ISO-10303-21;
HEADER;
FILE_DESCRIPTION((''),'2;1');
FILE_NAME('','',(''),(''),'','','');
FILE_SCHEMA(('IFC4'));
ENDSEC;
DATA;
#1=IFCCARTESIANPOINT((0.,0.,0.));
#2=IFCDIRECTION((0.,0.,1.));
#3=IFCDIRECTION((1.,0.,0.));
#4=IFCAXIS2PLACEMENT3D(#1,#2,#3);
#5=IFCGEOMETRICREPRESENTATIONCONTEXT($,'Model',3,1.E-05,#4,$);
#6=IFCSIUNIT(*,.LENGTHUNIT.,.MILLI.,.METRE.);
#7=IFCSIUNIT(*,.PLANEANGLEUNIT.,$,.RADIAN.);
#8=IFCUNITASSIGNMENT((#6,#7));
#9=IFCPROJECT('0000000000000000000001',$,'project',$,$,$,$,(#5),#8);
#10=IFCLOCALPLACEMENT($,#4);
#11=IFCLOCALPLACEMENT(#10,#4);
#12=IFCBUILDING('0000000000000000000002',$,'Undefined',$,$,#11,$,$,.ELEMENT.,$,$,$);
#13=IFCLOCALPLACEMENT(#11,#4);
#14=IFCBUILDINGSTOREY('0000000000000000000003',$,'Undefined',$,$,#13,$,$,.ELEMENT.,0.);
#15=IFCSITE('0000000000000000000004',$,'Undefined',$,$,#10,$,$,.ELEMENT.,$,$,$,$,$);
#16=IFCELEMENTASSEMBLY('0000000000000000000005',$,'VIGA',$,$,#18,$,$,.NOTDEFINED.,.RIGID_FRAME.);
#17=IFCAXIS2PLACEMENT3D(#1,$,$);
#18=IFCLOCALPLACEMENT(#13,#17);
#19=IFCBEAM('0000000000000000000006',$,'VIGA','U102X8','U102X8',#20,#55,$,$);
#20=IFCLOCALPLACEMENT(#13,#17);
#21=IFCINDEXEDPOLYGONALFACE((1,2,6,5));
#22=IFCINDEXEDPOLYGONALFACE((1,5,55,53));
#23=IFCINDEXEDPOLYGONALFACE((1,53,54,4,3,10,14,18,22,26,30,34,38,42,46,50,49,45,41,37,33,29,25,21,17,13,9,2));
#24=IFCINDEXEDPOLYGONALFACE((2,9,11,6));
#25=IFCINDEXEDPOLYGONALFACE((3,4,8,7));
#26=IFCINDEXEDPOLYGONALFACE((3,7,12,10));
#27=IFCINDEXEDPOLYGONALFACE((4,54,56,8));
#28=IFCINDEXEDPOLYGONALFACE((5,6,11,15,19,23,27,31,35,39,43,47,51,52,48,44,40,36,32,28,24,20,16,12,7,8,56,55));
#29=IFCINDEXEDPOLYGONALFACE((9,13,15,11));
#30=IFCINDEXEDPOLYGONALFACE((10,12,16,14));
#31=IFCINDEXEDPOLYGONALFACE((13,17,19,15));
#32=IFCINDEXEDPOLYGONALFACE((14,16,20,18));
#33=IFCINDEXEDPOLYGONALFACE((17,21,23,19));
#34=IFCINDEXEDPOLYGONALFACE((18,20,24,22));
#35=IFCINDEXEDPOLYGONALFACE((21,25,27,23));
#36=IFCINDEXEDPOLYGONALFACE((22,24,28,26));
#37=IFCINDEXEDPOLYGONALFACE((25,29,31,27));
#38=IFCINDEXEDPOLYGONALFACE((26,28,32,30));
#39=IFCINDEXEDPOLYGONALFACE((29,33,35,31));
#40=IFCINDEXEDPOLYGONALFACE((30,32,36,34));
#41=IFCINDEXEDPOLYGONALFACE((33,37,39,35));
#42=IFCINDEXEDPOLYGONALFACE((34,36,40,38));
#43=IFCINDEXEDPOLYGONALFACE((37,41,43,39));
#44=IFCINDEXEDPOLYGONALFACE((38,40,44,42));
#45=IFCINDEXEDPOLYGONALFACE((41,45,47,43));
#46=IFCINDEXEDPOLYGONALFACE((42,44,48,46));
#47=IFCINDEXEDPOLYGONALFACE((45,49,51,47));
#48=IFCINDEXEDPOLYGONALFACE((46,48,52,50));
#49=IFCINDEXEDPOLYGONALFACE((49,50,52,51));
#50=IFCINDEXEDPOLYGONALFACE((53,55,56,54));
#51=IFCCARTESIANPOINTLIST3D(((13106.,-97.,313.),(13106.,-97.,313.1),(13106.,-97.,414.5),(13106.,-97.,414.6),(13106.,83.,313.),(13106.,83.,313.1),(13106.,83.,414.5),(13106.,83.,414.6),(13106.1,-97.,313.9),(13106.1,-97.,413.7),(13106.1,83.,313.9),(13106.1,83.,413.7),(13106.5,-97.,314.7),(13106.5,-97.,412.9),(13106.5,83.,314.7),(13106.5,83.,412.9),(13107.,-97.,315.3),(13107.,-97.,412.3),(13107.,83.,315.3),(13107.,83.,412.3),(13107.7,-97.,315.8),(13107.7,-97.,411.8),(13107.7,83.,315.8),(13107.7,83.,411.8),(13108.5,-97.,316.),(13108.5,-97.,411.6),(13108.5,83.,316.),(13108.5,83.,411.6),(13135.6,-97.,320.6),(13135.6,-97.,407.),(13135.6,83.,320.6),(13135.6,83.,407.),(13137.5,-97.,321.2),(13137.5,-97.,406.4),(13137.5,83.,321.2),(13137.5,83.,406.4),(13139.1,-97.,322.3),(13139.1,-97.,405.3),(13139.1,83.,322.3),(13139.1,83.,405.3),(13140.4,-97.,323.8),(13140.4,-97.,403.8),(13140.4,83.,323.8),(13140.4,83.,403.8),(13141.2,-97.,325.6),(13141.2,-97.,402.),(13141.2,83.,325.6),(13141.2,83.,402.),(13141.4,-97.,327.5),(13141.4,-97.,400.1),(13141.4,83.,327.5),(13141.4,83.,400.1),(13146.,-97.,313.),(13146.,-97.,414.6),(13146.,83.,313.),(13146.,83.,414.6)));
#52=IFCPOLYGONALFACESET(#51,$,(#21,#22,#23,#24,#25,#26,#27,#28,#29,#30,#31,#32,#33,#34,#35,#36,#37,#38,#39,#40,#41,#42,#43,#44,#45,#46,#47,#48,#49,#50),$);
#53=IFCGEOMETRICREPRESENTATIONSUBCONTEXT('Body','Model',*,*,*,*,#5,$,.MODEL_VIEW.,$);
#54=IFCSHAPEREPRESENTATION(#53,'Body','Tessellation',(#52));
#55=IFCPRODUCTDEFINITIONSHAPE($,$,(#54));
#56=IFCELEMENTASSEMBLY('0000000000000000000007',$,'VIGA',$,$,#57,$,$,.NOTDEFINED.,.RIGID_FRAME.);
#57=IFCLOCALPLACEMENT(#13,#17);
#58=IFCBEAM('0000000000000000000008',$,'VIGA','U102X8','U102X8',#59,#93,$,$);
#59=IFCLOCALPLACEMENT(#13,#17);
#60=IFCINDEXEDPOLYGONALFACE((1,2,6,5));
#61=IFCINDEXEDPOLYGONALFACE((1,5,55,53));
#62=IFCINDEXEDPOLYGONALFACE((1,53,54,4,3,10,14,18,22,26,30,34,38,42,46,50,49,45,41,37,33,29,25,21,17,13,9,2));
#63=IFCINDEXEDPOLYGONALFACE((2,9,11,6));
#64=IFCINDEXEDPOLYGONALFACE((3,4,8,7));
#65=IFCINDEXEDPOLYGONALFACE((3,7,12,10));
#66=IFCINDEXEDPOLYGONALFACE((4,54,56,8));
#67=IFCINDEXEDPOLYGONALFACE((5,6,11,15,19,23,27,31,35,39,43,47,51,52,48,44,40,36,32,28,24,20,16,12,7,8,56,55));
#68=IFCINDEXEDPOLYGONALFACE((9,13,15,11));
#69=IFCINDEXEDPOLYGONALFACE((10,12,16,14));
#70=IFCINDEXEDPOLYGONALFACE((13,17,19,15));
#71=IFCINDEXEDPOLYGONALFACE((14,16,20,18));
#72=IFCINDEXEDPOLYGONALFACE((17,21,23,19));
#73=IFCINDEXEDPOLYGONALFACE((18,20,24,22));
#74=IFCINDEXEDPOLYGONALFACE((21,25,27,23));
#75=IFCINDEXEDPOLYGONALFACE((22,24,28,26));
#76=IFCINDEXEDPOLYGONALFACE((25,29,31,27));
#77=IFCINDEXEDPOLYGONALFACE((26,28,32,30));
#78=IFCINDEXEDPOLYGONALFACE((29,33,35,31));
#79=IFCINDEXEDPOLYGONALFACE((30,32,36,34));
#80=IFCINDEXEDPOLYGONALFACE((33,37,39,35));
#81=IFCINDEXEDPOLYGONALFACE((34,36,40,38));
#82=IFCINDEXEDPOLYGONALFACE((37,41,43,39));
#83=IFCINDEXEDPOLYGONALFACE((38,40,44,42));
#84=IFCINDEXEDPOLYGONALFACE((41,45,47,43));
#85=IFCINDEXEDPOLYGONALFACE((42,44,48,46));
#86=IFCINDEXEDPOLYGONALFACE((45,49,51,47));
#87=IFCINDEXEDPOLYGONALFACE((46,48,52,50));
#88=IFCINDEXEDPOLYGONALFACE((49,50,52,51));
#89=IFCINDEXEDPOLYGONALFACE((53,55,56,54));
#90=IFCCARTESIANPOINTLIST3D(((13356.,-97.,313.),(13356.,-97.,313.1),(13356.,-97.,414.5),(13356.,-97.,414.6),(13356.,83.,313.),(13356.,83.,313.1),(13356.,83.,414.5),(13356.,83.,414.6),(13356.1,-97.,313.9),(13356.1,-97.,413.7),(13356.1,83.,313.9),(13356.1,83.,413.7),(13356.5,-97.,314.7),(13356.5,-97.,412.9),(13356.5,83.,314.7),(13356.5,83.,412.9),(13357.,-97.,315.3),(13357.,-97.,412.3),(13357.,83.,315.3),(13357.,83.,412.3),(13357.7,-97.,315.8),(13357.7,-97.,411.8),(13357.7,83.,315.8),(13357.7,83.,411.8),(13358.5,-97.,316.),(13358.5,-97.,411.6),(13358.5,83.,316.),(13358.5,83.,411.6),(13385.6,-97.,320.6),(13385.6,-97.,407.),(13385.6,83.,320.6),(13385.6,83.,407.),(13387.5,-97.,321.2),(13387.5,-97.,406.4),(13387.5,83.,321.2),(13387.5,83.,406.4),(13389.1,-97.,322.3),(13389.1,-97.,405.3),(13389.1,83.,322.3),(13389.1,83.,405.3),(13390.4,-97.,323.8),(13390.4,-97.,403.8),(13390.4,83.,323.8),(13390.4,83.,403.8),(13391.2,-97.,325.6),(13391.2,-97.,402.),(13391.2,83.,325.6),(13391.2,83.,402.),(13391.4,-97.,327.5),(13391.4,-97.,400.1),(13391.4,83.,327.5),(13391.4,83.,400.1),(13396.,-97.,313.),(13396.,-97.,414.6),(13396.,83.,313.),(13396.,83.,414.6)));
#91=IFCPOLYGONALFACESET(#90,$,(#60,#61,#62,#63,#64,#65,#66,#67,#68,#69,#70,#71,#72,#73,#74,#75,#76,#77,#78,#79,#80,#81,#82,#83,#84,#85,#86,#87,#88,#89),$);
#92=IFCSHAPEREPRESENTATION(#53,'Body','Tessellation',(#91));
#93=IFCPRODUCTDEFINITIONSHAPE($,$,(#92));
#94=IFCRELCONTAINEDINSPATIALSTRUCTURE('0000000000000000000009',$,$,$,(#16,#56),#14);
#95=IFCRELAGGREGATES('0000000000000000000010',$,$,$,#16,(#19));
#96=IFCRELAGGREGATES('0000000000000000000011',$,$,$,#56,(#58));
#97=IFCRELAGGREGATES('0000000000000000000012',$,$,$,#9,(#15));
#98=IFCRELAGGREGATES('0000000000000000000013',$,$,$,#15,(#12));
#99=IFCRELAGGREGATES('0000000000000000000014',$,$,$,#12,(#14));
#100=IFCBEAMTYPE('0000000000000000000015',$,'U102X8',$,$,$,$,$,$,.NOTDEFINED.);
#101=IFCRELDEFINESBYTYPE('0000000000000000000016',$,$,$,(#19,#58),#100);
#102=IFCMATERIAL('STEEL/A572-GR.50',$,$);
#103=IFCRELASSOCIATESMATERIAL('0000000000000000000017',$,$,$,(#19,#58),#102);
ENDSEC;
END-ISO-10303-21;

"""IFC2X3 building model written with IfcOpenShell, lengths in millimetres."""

from ifc_helpers import new_model, si_unit, frame, origin_with_axes, origin_2d_with_axis, place, context, subcontext, project, spatial, u_section, extrude, material, type_object, element, aggregate, save


model = new_model("IFC2X3")

# Units and contexts
model_context = context("Model", 3, precision=1e-05, world=origin_with_axes())
body_context = subcontext(model_context, "Body", "Model", "MODEL_VIEW")
ifc_project = project(units=[si_unit("LENGTHUNIT", "METRE", prefix="MILLI"), si_unit("PLANEANGLEUNIT", "RADIAN")], contexts=[model_context])

# Site, building, storey
site_placement = place(None, origin_with_axes())
site = spatial("IfcSite", under=ifc_project, at=site_placement, Name="Undefined", CompositionType="ELEMENT")
building_placement = place(site_placement, origin_with_axes())
building = spatial("IfcBuilding", under=site, at=building_placement, Name="Undefined", CompositionType="ELEMENT")
storey_placement = place(building_placement, origin_with_axes())
storey = spatial("IfcBuildingStorey", under=building, at=storey_placement, Name="Undefined", CompositionType="ELEMENT", Elevation=0.0)

# Element assemblies, beams
ifc_material = material(Name="STEEL/A572-GR.50")
beam_type = type_object("IfcBeamType", Name="U102X8", PredefinedType="NOTDEFINED")
assembly_1_placement = place(storey_placement, origin_with_axes())
assembly_1 = element("IfcElementAssembly", 1, at=assembly_1_placement, inside=storey, Name="VIGA", AssemblyPlace="NOTDEFINED", PredefinedType="RIGID_FRAME")
beam_1_placement = place(assembly_1_placement, frame((13126.0, 83.0, 363.8), z_axis=(0.0, 0.0, 1.0), x_axis=(0.0, -1.0, 0.0)))
beam_1 = element("IfcBeam", 2, at=beam_1_placement, type_object=beam_type, material=ifc_material, Name="VIGA", Description="U102X8", ObjectType="U102X8", context=body_context, shape_type="SweptSolid", body=[
    extrude(u_section(Depth=101.6, FlangeWidth=40.0, WebThickness=4.6, FlangeThickness=6.0, FilletRadius=7.0, EdgeRadius=3.0, FlangeSlope=0.16839, at=origin_2d_with_axis()), frame((180.0, 0.0, 0.0), z_axis=(-1.0, 0.0, 0.0), x_axis=(0.0, -1.0, 0.0)), (0.0, 0.0, 1.0), 180.0),
])
aggregate(assembly_1, [beam_1])
assembly_2_placement = place(storey_placement, origin_with_axes())
assembly_2 = element("IfcElementAssembly", 3, at=assembly_2_placement, inside=storey, Name="VIGA", AssemblyPlace="NOTDEFINED", PredefinedType="RIGID_FRAME")
beam_2_placement = place(assembly_2_placement, frame((13376.0, 83.0, 363.8), z_axis=(0.0, 0.0, 1.0), x_axis=(0.0, -1.0, 0.0)))
beam_2 = element("IfcBeam", 4, at=beam_2_placement, type_object=beam_type, material=ifc_material, Name="VIGA", Description="U102X8", ObjectType="U102X8", context=body_context, shape_type="SweptSolid", body=[
    extrude(u_section(Depth=101.6, FlangeWidth=40.0, WebThickness=4.6, FlangeThickness=6.0, FilletRadius=7.0, EdgeRadius=3.0, FlangeSlope=0.16839, at=origin_2d_with_axis()), frame((180.0, 0.0, 0.0), z_axis=(-1.0, 0.0, 0.0), x_axis=(0.0, -1.0, 0.0)), (0.0, 0.0, 1.0), 180.0),
])
aggregate(assembly_2, [beam_2])

save(model, "model.ifc")
